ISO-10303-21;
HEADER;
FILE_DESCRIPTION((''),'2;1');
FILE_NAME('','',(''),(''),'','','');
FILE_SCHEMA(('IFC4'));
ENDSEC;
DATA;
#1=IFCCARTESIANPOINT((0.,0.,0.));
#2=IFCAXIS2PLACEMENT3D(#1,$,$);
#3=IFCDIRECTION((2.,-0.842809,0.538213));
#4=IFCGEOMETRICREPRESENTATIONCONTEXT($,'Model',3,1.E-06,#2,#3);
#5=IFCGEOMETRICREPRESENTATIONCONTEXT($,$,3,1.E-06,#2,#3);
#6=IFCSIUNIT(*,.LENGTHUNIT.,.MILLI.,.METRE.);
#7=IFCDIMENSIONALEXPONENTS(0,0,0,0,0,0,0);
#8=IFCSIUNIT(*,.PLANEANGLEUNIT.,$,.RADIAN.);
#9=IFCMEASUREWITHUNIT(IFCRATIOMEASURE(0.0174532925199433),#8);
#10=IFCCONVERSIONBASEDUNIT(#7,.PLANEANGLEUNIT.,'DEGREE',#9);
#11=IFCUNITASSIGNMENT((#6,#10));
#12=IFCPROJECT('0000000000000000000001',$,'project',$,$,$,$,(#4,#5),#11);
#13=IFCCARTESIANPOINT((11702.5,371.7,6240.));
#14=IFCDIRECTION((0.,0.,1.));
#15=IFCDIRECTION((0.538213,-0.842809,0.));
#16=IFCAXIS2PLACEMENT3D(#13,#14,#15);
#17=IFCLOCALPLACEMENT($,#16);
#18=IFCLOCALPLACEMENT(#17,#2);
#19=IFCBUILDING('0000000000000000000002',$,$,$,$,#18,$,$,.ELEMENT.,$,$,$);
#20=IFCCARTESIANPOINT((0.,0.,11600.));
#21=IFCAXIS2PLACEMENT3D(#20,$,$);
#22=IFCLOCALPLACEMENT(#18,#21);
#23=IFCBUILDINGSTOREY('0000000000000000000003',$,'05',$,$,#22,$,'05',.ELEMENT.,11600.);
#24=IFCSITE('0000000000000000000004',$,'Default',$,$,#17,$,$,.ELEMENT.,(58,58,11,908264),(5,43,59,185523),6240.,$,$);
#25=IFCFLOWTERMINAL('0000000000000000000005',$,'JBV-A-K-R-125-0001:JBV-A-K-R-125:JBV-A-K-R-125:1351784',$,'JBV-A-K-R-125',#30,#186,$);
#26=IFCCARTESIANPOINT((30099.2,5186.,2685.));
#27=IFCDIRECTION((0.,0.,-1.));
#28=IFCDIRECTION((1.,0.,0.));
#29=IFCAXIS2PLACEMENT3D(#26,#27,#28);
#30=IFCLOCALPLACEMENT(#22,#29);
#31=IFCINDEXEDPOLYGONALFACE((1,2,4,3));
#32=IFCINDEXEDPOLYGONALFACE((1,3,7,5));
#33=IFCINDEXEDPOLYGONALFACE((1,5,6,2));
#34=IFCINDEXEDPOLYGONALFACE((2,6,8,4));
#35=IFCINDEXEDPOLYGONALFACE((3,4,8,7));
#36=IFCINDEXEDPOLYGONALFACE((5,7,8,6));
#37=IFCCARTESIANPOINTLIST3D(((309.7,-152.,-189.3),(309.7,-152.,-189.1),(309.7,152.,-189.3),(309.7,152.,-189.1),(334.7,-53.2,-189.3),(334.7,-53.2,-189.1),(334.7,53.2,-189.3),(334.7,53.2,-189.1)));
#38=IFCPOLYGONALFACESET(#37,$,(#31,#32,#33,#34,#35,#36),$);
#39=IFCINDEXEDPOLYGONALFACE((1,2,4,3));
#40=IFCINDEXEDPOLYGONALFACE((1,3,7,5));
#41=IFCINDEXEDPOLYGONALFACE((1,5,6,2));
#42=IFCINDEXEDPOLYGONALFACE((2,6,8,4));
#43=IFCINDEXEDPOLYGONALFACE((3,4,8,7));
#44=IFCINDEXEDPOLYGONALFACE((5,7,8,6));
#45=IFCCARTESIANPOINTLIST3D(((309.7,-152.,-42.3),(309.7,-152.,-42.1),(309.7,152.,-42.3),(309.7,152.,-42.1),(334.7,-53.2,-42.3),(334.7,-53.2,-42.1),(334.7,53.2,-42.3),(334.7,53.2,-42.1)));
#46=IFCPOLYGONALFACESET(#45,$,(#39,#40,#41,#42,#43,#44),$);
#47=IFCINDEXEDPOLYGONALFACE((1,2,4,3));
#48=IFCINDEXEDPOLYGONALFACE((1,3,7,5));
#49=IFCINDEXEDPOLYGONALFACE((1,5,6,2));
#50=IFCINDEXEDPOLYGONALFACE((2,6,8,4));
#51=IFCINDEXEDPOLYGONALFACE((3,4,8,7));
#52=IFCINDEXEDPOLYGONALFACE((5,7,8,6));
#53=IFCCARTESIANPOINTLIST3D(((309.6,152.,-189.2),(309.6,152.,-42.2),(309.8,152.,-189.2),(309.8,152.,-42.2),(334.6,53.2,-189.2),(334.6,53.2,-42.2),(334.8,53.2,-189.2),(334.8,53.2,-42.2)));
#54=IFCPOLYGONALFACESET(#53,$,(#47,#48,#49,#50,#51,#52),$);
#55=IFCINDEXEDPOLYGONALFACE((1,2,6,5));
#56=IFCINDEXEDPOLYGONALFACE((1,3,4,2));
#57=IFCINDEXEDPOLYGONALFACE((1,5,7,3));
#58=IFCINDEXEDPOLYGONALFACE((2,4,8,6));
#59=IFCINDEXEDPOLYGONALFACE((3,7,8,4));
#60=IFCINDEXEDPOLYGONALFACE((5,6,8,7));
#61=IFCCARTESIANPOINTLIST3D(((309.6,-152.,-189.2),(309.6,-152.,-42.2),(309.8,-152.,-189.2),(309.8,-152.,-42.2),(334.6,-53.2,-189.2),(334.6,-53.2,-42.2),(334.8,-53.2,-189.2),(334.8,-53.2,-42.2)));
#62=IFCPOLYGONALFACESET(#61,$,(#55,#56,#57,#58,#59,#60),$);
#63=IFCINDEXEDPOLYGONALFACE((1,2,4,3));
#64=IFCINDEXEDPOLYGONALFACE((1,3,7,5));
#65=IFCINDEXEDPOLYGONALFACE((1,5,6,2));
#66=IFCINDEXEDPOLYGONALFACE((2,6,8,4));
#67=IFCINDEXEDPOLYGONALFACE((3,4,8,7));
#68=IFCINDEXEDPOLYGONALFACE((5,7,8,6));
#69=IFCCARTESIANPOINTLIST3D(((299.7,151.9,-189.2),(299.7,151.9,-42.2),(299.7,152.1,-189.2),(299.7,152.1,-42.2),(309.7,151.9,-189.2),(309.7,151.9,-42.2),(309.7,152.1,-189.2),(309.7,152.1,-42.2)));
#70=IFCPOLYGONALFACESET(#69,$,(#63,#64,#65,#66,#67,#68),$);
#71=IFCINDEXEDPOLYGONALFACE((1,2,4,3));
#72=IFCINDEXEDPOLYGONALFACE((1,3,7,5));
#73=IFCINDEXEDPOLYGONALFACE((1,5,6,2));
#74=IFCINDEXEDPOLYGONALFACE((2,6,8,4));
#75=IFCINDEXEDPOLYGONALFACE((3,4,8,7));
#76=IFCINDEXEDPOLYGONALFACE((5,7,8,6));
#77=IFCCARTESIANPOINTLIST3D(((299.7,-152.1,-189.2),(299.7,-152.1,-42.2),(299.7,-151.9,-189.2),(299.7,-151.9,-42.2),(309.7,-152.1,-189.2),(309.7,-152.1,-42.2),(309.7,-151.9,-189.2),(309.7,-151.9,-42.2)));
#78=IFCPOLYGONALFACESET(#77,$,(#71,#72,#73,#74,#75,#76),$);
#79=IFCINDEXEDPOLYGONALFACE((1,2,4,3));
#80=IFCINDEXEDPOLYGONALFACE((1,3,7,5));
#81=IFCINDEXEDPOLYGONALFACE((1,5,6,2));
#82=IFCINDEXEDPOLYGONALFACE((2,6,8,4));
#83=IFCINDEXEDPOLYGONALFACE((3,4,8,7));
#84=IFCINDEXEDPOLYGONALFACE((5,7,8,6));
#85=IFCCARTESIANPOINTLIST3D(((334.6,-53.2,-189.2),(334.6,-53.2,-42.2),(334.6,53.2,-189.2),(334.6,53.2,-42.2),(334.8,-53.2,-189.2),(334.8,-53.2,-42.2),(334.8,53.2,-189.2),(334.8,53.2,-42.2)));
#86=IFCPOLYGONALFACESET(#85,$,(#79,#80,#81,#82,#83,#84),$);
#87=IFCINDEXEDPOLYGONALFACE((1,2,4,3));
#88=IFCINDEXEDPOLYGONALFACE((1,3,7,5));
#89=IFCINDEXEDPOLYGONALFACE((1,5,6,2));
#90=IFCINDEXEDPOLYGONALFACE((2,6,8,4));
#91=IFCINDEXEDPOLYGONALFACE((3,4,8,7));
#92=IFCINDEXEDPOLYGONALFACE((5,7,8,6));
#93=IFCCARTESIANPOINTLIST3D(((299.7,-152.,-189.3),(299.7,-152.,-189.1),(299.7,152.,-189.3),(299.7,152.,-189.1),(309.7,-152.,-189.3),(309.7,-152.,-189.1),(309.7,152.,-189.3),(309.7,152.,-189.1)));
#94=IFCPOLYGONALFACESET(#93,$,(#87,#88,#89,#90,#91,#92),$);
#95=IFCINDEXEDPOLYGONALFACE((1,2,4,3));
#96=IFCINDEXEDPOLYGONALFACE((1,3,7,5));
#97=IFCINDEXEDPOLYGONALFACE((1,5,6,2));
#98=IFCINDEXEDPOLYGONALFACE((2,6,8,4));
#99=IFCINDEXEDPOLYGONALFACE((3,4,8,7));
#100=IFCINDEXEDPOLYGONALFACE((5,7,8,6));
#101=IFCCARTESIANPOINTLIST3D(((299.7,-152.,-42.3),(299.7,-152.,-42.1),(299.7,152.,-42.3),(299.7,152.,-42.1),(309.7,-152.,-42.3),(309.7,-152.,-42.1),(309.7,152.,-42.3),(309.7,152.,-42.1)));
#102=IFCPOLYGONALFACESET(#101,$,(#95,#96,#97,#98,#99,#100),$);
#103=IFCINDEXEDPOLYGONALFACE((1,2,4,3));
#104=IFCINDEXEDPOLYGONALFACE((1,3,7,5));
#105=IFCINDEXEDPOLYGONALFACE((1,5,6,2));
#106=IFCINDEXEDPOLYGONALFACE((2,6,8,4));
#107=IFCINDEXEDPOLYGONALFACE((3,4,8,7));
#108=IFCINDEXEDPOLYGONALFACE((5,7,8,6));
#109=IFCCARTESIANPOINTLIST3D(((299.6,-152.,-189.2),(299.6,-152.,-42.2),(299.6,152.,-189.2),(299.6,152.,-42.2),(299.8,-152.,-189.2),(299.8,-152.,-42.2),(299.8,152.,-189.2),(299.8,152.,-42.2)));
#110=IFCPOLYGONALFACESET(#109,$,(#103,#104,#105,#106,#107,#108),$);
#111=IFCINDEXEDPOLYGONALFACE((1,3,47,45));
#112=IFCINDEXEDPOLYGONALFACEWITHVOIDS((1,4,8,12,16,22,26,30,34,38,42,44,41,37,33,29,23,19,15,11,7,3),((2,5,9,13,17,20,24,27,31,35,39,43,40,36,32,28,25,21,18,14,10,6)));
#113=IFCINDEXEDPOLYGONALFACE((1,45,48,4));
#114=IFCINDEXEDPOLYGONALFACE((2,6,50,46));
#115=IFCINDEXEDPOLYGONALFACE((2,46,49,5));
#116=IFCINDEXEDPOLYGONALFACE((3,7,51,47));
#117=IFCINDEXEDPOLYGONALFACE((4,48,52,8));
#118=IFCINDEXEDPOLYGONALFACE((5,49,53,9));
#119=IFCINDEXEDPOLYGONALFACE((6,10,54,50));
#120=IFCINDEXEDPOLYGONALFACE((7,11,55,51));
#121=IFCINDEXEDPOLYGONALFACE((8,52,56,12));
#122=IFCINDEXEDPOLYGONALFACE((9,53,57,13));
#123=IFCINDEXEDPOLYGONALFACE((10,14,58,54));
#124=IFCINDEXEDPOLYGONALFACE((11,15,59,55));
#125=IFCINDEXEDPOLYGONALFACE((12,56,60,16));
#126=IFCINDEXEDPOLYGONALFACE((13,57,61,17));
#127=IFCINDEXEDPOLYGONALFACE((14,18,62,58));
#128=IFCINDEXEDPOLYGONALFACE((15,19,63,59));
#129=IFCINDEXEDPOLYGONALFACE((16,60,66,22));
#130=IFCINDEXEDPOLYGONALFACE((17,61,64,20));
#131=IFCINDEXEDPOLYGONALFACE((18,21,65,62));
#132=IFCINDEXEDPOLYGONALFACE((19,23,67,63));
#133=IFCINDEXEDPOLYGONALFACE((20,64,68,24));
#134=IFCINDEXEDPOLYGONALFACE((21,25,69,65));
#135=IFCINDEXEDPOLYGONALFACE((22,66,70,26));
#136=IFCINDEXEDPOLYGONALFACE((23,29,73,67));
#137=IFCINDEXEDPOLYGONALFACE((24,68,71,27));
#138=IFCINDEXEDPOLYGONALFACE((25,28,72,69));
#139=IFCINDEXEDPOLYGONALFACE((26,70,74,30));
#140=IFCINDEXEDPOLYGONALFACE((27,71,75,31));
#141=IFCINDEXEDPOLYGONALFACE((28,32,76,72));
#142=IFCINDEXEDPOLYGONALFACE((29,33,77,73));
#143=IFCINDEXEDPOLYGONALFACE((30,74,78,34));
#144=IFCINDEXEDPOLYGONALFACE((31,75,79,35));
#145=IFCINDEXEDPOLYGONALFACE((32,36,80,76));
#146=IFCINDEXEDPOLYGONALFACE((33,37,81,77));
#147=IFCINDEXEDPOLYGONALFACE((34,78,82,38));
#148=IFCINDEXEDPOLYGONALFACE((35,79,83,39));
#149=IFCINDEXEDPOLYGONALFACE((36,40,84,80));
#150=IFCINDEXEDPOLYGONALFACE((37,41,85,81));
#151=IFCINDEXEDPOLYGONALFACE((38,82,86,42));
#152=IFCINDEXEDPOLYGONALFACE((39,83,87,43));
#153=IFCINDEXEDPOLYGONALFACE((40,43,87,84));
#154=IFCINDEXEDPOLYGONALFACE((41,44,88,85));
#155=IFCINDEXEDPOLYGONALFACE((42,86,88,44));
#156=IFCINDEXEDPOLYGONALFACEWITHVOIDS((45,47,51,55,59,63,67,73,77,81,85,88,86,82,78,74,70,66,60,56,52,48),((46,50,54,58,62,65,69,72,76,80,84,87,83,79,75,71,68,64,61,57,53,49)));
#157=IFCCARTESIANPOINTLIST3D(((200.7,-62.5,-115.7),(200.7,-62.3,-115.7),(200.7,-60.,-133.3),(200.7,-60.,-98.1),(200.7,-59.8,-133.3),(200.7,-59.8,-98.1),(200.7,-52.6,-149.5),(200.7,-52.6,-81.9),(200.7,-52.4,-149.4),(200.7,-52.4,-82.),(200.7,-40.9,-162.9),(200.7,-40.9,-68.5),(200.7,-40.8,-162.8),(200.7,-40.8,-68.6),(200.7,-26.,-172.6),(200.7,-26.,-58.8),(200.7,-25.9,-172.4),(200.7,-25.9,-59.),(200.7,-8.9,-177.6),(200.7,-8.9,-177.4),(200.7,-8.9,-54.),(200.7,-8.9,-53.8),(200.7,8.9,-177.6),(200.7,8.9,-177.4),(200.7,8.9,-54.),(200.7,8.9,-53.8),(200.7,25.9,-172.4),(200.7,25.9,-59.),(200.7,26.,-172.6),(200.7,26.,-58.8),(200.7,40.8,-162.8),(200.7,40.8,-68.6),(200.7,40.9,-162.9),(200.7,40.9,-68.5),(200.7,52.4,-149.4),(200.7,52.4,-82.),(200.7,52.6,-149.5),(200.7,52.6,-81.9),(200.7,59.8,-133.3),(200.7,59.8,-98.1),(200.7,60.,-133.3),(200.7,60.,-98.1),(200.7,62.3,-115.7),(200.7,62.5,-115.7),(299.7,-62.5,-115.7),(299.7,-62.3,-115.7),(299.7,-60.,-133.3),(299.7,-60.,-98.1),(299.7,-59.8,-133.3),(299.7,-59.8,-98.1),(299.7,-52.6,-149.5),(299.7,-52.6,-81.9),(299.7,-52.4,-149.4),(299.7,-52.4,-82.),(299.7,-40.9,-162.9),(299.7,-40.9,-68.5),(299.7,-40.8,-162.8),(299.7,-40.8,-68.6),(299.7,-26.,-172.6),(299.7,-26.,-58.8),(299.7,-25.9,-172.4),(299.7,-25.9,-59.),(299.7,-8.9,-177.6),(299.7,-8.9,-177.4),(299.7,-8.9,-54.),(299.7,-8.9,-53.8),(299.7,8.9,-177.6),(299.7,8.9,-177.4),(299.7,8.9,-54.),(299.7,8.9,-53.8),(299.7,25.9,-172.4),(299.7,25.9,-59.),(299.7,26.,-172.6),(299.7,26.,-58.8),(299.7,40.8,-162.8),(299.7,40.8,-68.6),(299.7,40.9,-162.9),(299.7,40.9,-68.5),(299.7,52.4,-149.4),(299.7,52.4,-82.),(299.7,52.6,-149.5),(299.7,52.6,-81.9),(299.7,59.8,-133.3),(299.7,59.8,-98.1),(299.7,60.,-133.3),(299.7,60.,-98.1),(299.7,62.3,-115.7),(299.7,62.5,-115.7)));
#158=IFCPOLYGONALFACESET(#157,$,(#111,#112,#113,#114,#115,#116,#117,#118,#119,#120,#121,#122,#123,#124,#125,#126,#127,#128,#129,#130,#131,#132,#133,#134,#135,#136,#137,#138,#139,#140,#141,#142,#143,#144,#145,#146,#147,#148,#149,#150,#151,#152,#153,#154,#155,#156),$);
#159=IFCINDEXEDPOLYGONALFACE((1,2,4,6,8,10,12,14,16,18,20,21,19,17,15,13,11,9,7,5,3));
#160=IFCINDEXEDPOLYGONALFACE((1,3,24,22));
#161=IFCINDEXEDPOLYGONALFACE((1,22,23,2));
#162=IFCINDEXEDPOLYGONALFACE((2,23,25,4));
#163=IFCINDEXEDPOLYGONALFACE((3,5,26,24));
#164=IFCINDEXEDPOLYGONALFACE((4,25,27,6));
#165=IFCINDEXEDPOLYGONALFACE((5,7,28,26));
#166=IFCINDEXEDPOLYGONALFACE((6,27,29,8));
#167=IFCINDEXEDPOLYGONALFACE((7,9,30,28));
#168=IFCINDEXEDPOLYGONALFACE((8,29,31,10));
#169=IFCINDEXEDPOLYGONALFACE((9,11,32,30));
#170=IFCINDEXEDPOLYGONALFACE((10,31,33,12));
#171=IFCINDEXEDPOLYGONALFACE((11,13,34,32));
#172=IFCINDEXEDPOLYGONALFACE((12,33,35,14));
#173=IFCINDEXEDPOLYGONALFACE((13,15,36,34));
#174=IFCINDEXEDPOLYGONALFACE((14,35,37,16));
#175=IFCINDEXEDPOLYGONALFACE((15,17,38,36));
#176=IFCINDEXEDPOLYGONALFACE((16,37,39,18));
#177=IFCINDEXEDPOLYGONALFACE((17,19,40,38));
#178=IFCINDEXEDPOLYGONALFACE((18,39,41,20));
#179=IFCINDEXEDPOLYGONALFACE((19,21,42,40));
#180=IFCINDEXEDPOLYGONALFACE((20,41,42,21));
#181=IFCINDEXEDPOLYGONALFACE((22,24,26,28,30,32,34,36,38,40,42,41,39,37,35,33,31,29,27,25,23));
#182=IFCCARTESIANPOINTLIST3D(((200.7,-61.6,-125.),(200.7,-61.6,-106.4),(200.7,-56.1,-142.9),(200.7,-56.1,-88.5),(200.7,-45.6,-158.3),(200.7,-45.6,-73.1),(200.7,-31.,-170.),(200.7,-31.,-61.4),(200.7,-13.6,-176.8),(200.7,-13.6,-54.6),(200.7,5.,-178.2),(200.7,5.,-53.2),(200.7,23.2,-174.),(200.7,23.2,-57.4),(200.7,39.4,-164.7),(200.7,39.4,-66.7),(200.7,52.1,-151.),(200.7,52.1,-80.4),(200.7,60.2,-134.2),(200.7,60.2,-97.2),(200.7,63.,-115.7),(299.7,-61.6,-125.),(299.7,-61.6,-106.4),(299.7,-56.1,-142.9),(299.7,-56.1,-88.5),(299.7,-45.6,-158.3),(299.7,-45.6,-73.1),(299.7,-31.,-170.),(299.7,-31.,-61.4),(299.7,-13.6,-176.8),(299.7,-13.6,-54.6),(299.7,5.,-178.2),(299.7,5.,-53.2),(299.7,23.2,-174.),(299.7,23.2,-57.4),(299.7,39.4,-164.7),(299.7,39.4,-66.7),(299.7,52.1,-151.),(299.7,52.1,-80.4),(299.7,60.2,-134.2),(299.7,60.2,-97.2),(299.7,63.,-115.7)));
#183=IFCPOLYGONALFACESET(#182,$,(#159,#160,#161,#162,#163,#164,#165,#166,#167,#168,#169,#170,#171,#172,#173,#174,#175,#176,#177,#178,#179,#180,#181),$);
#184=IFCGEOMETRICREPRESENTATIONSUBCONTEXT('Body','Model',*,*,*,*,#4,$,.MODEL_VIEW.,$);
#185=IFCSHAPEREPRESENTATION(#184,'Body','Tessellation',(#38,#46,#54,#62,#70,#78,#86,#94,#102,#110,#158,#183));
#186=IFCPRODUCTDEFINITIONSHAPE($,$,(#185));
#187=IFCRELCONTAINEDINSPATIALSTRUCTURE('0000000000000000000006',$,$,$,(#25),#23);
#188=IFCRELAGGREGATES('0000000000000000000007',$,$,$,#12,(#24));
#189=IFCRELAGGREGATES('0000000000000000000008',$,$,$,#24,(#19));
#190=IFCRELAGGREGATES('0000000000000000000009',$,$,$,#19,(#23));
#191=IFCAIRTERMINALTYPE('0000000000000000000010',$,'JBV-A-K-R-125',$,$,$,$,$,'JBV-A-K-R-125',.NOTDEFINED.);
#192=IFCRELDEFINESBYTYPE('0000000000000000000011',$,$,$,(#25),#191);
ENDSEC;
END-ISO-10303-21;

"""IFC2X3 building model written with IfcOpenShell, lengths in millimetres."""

from ifc_helpers import new_model, entity, si_unit, converted_unit, direction, frame, frame_2d, origin, origin_2d_with_axis, place, context, subcontext, project, spatial, polyline, circle_curve, parameter, trimmed, segment, composite_curve, rectangle, circle, outline, extrude, source, transform, mapped, type_object, type_shapes, element, save


model = new_model("IFC2X3")

# Units and contexts
model_context = context("Model", 3, precision=1e-06, world=origin(), true_north=direction((2.0, -0.842809, 0.538213)))
context_of_model = context(None, 3, precision=1e-06, world=origin(), true_north=direction((2.0, -0.842809, 0.538213)))
body_context = subcontext(model_context, "Body", "Model", "MODEL_VIEW")
ifc_project = project(units=[si_unit("LENGTHUNIT", "METRE", prefix="MILLI"), converted_unit("PLANEANGLEUNIT", "DEGREE", entity("IfcRatioMeasure", 0.0174532925199433), si_unit("PLANEANGLEUNIT", "RADIAN"), dimensions=[0, 0, 0, 0, 0, 0, 0])], contexts=[model_context, context_of_model])

# Site, building, storey
site_placement = place(None, frame((11702.5, 371.7, 6240.0), z_axis=(0.0, 0.0, 1.0), x_axis=(0.538213, -0.842809, 0.0)))
site = spatial("IfcSite", under=ifc_project, at=site_placement, Name="Default", CompositionType="ELEMENT", RefLatitude=(58, 58, 11, 908264), RefLongitude=(5, 43, 59, 185523), RefElevation=6240.0)
building_placement = place(site_placement, origin())
building = spatial("IfcBuilding", under=site, at=building_placement, CompositionType="ELEMENT")
storey_placement = place(building_placement, frame((0.0, 0.0, 11600.0)))
storey = spatial("IfcBuildingStorey", under=building, at=storey_placement, Name="05", LongName="05", CompositionType="ELEMENT", Elevation=11600.0)

# Flow terminal
air_terminal_type = type_object("IfcAirTerminalType", Name="JBV-A-K-R-125", ElementType="JBV-A-K-R-125", PredefinedType="NOTDEFINED")
shared_shape_1 = source(origin(), body_context, "Body", "SweptSolid", [
    extrude(outline(polyline([(-152.0, -12.5), (152.0, -12.5), (53.2, 12.5), (-53.2, 12.5), (-152.0, -12.5)])), frame((322.2, 0.0, -189.3), z_axis=(0.0, 0.0, 1.0), x_axis=(0.0, -1.0, 0.0)), (0.0, 0.0, 1.0), 0.2),
    extrude(outline(polyline([(-152.0, -12.5), (152.0, -12.5), (53.2, 12.5), (-53.2, 12.5), (-152.0, -12.5)])), frame((322.2, 0.0, -42.3), z_axis=(0.0, 0.0, 1.0), x_axis=(0.0, -1.0, 0.0)), (0.0, 0.0, 1.0), 0.2),
    extrude(rectangle(XDim=0.2, YDim=101.9, at=frame_2d((0.0, 0.0), x_axis=(1.0, 0.0))), frame((322.2, 102.6, -189.2), z_axis=(0.0, 0.0, 1.0), x_axis=(0.969446, 0.245305, 0.0)), (0.0, 0.0, 1.0), 147.0),
    extrude(rectangle(XDim=0.2, YDim=101.9, at=frame_2d((0.0, 0.0), x_axis=(1.0, 0.0))), frame((322.2, -102.6, -189.2), z_axis=(0.0, 0.0, 1.0), x_axis=(-0.969446, 0.245305, 0.0)), (0.0, 0.0, 1.0), 147.0),
    extrude(rectangle(XDim=0.2, YDim=10.0, at=frame_2d((0.0, 0.0), x_axis=(1.0, 0.0))), frame((304.7, 152.0, -189.2), z_axis=(0.0, 0.0, 1.0), x_axis=(0.0, 1.0, 0.0)), (0.0, 0.0, 1.0), 147.0),
    extrude(rectangle(XDim=0.2, YDim=10.0, at=frame_2d((0.0, 0.0), x_axis=(1.0, 0.0))), frame((304.7, -152.0, -189.2), z_axis=(0.0, 0.0, 1.0), x_axis=(0.0, 1.0, 0.0)), (0.0, 0.0, 1.0), 147.0),
    extrude(rectangle(XDim=0.2, YDim=106.4, at=frame_2d((0.0, 0.0), x_axis=(1.0, 0.0))), frame((334.7, 0.0, -189.2)), (0.0, 0.0, 1.0), 147.0),
    extrude(rectangle(XDim=304.0, YDim=10.0, at=frame_2d((0.0, 0.0), x_axis=(1.0, 0.0))), frame((304.7, 0.0, -189.3), z_axis=(0.0, 0.0, 1.0), x_axis=(0.0, -1.0, 0.0)), (0.0, 0.0, 1.0), 0.2),
    extrude(rectangle(XDim=304.0, YDim=10.0, at=frame_2d((0.0, 0.0), x_axis=(1.0, 0.0))), frame((304.7, 0.0, -42.3), z_axis=(0.0, 0.0, 1.0), x_axis=(0.0, -1.0, 0.0)), (0.0, 0.0, 1.0), 0.2),
    extrude(rectangle(XDim=0.2, YDim=304.0, at=frame_2d((0.0, 0.0), x_axis=(1.0, 0.0))), frame((299.7, 0.0, -189.2)), (0.0, 0.0, 1.0), 147.0),
    extrude(outline(composite_curve([segment(trimmed(circle_curve(origin_2d_with_axis(), 62.5), [parameter(0.0)], [parameter(180.0)], True, "PARAMETER"), True, "CONTINUOUS"), segment(trimmed(circle_curve(origin_2d_with_axis(), 62.5), [parameter(180.0)], [parameter(360.0)], True, "PARAMETER"), True, "CONTINUOUS")], self_intersect=False), holes=[composite_curve([segment(trimmed(circle_curve(origin_2d_with_axis(), 62.3), [parameter(180.0)], [parameter(360.0)], True, "PARAMETER"), False, "CONTINUOUS"), segment(trimmed(circle_curve(origin_2d_with_axis(), 62.3), [parameter(0.0)], [parameter(180.0)], True, "PARAMETER"), False, "CONTINUOUS")], self_intersect=False)]), frame((200.7, 0.0, -115.7), z_axis=(1.0, 0.0, 0.0), x_axis=(0.0, 1.0, 0.0)), (0.0, 0.0, 1.0), 99.0),
    extrude(circle(Radius=62.6, at=frame_2d((0.0, 0.0), x_axis=(1.0, 0.0))), frame((200.7, 0.3, -115.7), z_axis=(1.0, 0.0, 0.0), x_axis=(0.0, 1.0, 0.0)), (0.0, 0.0, 1.0), 99.0),
])
type_shapes(air_terminal_type, [shared_shape_1])
flow_terminal_placement = place(storey_placement, frame((30099.2, 5186.0, 2685.0), z_axis=(0.0, 0.0, -1.0), x_axis=(1.0, 0.0, 0.0)))
element("IfcFlowTerminal", 1, at=flow_terminal_placement, inside=storey, type_object=air_terminal_type, Name="JBV-A-K-R-125-0001:JBV-A-K-R-125:JBV-A-K-R-125:1351784", ObjectType="JBV-A-K-R-125", context=body_context, shape_type="MappedRepresentation", body=[
    mapped(shared_shape_1, transform((0.0, 0.0, 0.0), scale=1.0)),
])

save(model, "model.ifc")
